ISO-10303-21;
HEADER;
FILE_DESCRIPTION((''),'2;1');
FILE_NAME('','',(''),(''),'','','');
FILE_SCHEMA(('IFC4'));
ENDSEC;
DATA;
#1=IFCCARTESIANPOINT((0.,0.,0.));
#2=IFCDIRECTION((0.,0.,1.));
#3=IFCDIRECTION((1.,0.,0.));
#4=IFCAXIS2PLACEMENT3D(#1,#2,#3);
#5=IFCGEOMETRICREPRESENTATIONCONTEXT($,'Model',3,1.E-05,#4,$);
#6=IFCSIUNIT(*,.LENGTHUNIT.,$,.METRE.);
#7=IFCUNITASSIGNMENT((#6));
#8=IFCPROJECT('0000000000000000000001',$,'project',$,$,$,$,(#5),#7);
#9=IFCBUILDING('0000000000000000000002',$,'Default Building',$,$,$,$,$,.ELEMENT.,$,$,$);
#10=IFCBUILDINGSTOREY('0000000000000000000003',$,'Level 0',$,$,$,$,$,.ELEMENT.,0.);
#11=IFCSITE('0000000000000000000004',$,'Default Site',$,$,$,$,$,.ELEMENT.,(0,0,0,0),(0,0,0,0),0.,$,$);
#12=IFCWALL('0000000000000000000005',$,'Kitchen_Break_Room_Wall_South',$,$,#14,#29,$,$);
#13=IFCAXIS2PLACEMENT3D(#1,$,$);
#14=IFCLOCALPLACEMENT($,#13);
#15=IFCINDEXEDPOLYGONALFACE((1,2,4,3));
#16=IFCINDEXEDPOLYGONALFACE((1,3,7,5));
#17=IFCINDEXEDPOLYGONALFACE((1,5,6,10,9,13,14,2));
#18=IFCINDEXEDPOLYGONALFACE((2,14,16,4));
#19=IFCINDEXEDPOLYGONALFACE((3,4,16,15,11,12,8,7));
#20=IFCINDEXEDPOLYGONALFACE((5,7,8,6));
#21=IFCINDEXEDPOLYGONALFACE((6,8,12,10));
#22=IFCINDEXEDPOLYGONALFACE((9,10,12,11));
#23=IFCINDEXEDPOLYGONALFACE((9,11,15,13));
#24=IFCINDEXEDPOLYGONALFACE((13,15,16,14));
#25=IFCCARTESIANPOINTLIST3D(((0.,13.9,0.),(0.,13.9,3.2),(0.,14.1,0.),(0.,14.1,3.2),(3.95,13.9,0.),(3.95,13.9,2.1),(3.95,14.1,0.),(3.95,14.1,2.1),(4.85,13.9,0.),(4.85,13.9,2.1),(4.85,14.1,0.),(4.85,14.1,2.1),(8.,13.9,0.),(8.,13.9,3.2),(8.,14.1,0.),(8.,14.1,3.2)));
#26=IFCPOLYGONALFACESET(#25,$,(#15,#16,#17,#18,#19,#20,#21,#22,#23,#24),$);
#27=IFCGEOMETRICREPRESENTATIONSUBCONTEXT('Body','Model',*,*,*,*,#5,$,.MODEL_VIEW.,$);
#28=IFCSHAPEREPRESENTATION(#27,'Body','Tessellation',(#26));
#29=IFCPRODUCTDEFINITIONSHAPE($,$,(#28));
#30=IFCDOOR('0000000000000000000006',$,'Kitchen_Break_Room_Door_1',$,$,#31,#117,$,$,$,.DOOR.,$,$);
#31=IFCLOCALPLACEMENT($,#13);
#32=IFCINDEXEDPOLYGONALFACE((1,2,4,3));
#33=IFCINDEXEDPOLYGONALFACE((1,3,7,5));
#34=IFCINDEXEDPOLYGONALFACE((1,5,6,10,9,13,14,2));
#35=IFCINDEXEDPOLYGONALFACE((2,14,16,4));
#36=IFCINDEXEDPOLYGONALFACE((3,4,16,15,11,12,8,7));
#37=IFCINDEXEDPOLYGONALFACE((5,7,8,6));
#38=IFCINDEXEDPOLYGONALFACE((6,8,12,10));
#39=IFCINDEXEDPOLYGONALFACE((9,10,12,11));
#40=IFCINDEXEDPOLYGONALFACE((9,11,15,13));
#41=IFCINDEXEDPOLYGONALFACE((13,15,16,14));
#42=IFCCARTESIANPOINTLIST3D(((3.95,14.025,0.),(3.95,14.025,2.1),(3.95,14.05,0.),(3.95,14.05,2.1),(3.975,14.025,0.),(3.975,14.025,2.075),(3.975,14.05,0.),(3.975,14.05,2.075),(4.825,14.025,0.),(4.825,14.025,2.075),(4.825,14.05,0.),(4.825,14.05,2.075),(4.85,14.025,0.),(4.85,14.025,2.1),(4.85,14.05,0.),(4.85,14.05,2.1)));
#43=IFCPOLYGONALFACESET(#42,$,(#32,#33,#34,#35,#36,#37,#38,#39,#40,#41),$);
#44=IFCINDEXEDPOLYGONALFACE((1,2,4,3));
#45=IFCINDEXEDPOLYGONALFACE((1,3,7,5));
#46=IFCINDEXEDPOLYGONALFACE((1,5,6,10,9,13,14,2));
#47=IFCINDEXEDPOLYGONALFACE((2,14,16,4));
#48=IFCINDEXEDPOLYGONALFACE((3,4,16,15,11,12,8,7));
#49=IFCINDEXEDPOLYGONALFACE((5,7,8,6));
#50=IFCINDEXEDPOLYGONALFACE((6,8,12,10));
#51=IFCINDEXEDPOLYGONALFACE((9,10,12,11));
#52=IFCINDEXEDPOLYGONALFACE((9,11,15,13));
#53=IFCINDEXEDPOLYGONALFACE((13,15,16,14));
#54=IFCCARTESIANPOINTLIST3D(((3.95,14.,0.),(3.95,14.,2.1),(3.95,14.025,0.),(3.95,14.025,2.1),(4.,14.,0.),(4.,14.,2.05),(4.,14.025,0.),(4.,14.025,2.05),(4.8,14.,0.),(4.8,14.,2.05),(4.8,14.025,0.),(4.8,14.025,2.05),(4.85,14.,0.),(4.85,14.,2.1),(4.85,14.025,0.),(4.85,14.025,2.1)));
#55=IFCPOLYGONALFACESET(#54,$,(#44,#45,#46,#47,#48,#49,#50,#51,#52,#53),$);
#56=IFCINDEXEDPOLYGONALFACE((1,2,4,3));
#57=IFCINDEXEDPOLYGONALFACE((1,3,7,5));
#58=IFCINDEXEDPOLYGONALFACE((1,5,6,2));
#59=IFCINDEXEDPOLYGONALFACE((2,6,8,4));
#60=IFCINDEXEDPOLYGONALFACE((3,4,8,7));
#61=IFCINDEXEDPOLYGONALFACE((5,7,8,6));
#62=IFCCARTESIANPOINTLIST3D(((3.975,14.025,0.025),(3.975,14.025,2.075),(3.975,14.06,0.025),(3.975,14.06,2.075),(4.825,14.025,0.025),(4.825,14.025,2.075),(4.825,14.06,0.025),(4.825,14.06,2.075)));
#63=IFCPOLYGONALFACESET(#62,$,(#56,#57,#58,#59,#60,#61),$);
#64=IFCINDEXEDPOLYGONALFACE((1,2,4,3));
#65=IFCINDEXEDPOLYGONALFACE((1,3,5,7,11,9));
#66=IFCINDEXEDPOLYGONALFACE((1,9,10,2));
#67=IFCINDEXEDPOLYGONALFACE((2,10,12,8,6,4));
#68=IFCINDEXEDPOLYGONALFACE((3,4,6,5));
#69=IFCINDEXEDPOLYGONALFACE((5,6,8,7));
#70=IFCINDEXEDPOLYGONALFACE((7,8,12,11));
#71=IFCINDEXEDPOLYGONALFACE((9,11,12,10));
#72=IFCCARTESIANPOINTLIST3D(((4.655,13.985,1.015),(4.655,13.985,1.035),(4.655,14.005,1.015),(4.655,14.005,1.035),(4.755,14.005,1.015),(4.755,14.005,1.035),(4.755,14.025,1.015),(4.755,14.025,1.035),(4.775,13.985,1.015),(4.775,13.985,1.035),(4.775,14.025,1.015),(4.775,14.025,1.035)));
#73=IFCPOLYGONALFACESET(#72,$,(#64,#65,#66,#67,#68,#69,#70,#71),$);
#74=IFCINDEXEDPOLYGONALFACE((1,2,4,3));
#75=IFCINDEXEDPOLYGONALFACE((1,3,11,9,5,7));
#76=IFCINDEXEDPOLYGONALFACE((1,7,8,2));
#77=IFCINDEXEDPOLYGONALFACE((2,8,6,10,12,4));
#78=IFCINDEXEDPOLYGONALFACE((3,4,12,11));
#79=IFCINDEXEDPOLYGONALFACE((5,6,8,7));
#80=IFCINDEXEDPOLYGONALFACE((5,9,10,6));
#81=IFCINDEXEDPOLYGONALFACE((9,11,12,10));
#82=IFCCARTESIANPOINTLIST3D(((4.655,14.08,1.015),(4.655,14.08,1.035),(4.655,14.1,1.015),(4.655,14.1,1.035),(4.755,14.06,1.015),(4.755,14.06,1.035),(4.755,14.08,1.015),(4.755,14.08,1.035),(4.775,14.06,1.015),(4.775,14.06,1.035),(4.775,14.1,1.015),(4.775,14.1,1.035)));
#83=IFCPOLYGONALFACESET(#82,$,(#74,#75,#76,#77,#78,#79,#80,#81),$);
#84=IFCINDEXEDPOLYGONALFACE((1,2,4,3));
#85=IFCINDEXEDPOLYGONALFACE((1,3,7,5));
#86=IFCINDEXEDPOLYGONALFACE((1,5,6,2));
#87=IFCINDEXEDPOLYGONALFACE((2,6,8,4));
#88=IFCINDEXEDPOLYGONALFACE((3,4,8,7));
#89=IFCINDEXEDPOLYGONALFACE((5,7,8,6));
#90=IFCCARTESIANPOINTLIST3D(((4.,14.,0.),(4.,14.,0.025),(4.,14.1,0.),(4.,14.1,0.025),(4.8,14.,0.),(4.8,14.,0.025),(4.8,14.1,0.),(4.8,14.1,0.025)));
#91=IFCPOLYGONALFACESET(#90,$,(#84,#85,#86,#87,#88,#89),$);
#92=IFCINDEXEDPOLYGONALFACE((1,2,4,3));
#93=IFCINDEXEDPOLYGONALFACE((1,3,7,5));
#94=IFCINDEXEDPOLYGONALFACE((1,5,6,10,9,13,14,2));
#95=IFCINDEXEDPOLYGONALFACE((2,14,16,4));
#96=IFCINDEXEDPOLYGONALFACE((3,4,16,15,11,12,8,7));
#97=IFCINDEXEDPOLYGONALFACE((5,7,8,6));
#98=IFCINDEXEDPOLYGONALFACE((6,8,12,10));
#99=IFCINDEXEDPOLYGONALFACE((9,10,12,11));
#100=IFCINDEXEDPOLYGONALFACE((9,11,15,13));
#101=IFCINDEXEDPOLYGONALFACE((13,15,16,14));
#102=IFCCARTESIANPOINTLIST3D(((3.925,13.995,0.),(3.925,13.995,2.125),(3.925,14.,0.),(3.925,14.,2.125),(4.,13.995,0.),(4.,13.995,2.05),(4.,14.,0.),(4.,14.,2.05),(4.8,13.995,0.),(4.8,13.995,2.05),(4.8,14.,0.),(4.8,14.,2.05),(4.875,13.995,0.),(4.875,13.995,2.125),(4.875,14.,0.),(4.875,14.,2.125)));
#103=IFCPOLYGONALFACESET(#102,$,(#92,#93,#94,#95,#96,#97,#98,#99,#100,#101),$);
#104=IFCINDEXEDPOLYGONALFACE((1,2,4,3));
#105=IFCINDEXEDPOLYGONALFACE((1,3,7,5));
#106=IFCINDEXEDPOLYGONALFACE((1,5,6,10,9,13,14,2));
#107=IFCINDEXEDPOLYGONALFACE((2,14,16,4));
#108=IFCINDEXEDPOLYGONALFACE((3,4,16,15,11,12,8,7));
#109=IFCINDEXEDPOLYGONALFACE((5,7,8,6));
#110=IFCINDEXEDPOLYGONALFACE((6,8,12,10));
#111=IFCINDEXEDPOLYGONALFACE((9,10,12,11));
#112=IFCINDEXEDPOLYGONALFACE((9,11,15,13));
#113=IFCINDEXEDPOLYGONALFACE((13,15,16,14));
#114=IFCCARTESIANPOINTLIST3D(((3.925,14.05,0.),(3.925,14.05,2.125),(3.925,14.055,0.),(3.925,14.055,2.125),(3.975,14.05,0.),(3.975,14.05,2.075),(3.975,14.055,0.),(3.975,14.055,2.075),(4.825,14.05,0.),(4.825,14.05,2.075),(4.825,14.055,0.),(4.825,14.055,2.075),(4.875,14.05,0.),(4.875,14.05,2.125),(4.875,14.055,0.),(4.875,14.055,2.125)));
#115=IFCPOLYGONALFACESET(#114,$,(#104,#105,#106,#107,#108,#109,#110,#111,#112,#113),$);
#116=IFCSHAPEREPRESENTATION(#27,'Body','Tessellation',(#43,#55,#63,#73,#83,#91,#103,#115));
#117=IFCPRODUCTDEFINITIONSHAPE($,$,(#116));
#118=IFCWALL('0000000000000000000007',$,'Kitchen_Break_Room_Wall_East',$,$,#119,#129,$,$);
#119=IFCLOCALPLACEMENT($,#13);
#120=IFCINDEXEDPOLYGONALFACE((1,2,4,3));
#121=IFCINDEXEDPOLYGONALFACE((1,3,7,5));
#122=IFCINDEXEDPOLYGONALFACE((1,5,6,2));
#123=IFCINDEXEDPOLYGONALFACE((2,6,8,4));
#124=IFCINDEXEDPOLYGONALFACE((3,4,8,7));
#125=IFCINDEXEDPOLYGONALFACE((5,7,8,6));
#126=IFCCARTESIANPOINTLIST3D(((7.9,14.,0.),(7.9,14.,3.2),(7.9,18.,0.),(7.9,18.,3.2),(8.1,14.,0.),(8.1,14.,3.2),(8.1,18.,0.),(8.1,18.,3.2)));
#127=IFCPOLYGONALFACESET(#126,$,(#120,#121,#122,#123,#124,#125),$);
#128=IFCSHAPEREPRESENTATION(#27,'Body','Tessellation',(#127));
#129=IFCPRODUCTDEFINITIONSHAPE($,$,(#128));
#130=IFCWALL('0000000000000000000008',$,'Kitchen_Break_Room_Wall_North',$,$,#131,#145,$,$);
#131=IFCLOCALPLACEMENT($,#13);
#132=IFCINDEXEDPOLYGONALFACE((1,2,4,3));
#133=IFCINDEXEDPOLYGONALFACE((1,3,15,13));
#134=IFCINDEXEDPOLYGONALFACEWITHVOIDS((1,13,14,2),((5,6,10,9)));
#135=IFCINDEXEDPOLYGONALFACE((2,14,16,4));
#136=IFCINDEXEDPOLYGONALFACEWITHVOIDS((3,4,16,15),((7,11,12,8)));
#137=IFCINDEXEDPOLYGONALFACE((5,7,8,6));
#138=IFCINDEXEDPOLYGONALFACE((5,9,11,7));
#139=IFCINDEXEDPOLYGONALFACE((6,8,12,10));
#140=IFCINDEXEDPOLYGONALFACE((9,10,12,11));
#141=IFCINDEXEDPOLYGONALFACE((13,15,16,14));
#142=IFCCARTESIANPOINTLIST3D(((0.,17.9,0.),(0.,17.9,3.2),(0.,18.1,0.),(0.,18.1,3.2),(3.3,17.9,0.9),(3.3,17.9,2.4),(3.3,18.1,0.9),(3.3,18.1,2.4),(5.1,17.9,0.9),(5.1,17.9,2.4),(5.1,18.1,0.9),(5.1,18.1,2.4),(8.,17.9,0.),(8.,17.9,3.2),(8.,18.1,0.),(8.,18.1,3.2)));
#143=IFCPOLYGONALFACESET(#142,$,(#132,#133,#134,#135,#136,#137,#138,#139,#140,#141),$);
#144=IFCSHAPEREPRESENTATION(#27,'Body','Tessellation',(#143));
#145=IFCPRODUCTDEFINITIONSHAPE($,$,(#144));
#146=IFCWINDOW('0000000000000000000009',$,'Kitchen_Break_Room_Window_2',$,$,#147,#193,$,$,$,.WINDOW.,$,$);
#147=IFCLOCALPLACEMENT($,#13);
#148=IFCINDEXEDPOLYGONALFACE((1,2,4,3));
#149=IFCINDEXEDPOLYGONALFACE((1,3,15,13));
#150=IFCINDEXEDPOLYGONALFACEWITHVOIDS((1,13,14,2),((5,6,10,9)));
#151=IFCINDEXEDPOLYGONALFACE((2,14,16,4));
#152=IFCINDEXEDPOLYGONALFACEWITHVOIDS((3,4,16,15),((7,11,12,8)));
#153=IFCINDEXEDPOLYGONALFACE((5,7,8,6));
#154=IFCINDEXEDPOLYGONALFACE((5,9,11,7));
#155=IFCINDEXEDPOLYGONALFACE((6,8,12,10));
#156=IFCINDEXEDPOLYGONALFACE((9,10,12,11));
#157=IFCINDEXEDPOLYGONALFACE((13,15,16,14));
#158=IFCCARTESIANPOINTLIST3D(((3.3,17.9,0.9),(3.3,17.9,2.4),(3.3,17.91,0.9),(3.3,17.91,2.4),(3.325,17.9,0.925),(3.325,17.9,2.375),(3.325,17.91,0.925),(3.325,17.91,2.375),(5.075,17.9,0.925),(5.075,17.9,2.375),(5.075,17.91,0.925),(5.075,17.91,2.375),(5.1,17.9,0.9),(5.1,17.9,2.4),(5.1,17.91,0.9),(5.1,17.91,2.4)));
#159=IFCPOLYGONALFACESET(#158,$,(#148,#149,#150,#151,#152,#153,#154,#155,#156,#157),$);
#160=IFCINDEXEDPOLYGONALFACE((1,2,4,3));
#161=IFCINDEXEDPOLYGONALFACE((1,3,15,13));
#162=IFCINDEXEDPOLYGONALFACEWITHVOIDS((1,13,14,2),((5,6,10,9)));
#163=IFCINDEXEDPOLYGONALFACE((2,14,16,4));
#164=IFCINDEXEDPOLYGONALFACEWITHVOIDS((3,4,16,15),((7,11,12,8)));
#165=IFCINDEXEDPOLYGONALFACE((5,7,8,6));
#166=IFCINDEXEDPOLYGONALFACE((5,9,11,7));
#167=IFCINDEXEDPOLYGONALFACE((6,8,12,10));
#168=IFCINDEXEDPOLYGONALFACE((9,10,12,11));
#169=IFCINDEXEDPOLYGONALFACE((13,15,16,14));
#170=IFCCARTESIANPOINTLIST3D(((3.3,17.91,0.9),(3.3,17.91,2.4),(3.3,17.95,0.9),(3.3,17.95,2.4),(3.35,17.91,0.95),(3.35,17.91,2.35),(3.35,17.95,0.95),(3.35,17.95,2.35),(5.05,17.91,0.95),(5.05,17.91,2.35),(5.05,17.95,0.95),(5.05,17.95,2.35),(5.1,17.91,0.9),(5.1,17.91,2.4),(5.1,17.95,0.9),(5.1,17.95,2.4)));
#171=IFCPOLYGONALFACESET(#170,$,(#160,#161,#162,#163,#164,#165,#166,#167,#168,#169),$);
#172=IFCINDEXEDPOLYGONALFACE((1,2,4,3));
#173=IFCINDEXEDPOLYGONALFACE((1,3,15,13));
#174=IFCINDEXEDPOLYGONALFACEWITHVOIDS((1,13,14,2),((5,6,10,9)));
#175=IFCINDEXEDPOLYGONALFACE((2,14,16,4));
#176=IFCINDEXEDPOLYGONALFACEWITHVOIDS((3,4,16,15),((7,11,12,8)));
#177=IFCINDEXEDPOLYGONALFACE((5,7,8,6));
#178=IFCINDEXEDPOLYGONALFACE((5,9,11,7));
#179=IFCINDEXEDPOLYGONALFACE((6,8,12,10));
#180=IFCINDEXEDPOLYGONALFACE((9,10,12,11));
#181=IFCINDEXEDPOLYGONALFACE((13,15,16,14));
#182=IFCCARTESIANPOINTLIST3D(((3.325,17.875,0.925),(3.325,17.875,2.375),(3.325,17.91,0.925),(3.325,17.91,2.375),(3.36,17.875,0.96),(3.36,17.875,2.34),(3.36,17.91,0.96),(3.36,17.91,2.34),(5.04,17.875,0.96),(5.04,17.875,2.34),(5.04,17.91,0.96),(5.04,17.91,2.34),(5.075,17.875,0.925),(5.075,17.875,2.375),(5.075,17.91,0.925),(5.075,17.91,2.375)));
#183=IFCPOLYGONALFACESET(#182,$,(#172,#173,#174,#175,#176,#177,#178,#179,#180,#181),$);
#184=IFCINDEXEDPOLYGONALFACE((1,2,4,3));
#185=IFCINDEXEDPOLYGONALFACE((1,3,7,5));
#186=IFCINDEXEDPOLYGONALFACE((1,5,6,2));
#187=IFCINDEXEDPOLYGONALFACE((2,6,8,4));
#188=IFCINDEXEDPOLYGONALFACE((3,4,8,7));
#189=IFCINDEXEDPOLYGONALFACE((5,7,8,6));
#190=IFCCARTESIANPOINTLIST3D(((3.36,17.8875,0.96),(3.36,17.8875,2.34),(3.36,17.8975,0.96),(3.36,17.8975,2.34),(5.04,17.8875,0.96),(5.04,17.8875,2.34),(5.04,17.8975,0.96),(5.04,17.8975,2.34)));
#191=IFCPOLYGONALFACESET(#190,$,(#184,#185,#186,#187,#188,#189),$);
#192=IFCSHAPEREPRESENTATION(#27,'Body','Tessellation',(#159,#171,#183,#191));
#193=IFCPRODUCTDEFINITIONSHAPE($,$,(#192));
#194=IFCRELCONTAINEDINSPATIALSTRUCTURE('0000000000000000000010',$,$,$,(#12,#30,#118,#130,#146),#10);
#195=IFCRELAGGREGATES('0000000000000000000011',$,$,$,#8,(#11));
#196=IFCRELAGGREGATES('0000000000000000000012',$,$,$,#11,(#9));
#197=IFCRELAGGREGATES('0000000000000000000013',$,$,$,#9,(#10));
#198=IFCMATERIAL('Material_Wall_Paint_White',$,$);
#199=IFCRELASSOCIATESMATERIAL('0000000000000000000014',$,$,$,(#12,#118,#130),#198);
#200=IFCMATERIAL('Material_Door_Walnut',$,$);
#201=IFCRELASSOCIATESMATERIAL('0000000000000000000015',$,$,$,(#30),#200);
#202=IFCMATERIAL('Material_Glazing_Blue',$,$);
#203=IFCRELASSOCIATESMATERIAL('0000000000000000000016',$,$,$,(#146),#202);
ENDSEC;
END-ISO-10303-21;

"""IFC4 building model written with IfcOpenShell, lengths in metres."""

from ifc_helpers import new_model, si_unit, frame, origin_with_axes, place, context, subcontext, project, spatial, line, indexed_curve, outline, extrude, material, element, fill, save


model = new_model("IFC4")

# Units and contexts
model_context = context("Model", 3, precision=1e-05, world=origin_with_axes())
body_context = subcontext(model_context, "Body", "Model", "MODEL_VIEW")
ifc_project = project(units=[si_unit("LENGTHUNIT", "METRE")], contexts=[model_context])

# Site, building, storey
site = spatial("IfcSite", under=ifc_project, Name="Default Site", CompositionType="ELEMENT", RefLatitude=(0, 0, 0, 0), RefLongitude=(0, 0, 0, 0), RefElevation=0.0)
building = spatial("IfcBuilding", under=site, Name="Default Building", CompositionType="ELEMENT")
storey = spatial("IfcBuildingStorey", under=building, Name="Level 0", CompositionType="ELEMENT", Elevation=0.0)

# Shared definitions
ifc_material_1 = material(Name="Material_Wall_Paint_White")

# Shared definitions
ifc_material_2 = material(Name="Material_Glazing_Blue")

# Shared definitions
ifc_material_3 = material(Name="Material_Door_Walnut")

# Wall, opening, door
wall_1_placement = place(None, frame((0.0, 14.0, 0.0), z_axis=(0.0, 0.0, 1.0), x_axis=(1.0, 0.0, 0.0)))
wall_1 = element("IfcWall", 1, at=wall_1_placement, inside=storey, material=ifc_material_1, Name="Kitchen_Break_Room_Wall_South", context=body_context, shape_type="SweptSolid", body=[
    extrude(outline(indexed_curve([(0.0, 0.0), (0.0, 0.2), (8.0, 0.2), (8.0, 0.0), (0.0, 0.0)], self_intersect=False)), frame((0.0, -0.1, 0.0), z_axis=(0.0, 0.0, 1.0), x_axis=(1.0, 0.0, 0.0)), (0.0, 0.0, 1.0), 3.2),
])
opening_1_placement = place(wall_1_placement, frame((3.95, -0.5, 0.0), z_axis=(0.0, 0.0, 1.0), x_axis=(1.0, 0.0, 0.0)))
opening_1 = element("IfcOpeningElement", 2, at=opening_1_placement, inside=storey, cuts=wall_1, PredefinedType="OPENING", context=body_context, shape_type="SweptSolid", body=[
    extrude(outline(indexed_curve([(0.0, 0.0), (0.0, 1.0), (0.9, 1.0), (0.9, 0.0), (0.0, 0.0)], self_intersect=False)), origin_with_axes(), (0.0, 0.0, 1.0), 2.1),
])
door_1_placement = place(None, frame((3.95, 14.0, 0.0), z_axis=(0.0, 0.0, 1.0), x_axis=(1.0, 0.0, 0.0)))
door_1 = element("IfcDoor", 3, at=door_1_placement, inside=storey, material=ifc_material_3, Name="Kitchen_Break_Room_Door_1", PredefinedType="DOOR", context=body_context, shape_type="SweptSolid", body=[
    extrude(outline(indexed_curve([(0.0, 0.0), (0.0, 2.1), (0.9, 2.1), (0.9, 0.0), (0.875, 0.0), (0.875, 2.075), (0.025, 2.075), (0.025, 0.0)], segments=[line(1, 2, 3, 4, 5, 6, 7, 8, 1)])), frame((0.0, 0.025, 0.0), z_axis=(0.0, -1.0, 0.0), x_axis=(1.0, 0.0, 0.0)), (0.0, 0.0, -1.0), 0.025),
    extrude(outline(indexed_curve([(0.0, 0.0), (0.0, 2.1), (0.9, 2.1), (0.9, 0.0), (0.85, 0.0), (0.85, 2.05), (0.05, 2.05), (0.05, 0.0)], segments=[line(1, 2, 3, 4, 5, 6, 7, 8, 1)])), frame((0.0, 0.0, 0.0), z_axis=(0.0, -1.0, 0.0), x_axis=(1.0, 0.0, 0.0)), (0.0, 0.0, -1.0), 0.025),
    extrude(outline(indexed_curve([(0.0, 0.0), (0.85, 0.0), (0.85, 0.035), (0.0, 0.035)], segments=[line(1, 2, 3, 4, 1)])), frame((0.025, 0.025, 0.025), z_axis=(0.0, 0.0, 1.0), x_axis=(1.0, 0.0, 0.0)), (0.0, 0.0, 1.0), 2.05),
    extrude(outline(indexed_curve([(0.0, 0.0), (0.0, -0.04), (-0.12, -0.04), (-0.12, -0.02), (-0.02, -0.02), (-0.02, 0.0)], segments=[line(1, 2, 3, 4, 5, 6, 1)])), frame((0.825, 0.025, 1.015), z_axis=(0.0, 0.0, 1.0), x_axis=(1.0, 0.0, 0.0)), (0.0, 0.0, 1.0), 0.02),
    extrude(outline(indexed_curve([(0.0, 0.0), (0.0, 0.04), (-0.12, 0.04), (-0.12, 0.02), (-0.02, 0.02), (-0.02, 0.0)], segments=[line(1, 2, 3, 4, 5, 6, 1)])), frame((0.825, 0.06, 1.015), z_axis=(0.0, 0.0, 1.0), x_axis=(1.0, 0.0, 0.0)), (0.0, 0.0, 1.0), 0.02),
    extrude(outline(indexed_curve([(0.0, 0.0), (0.8, 0.0), (0.8, 0.1), (0.0, 0.1)], segments=[line(1, 2, 3, 4, 1)])), frame((0.05, 0.0, 0.0), z_axis=(0.0, 0.0, 1.0), x_axis=(1.0, 0.0, 0.0)), (0.0, 0.0, 1.0), 0.025),
    extrude(outline(indexed_curve([(0.0, 0.0), (0.0, 2.125), (0.95, 2.125), (0.95, 0.0), (0.875, 0.0), (0.875, 2.05), (0.075, 2.05), (0.075, 0.0)], segments=[line(1, 2, 3, 4, 5, 6, 7, 8, 1)])), frame((-0.025, -0.005, 0.0), z_axis=(0.0, -1.0, 0.0), x_axis=(1.0, 0.0, 0.0)), (0.0, 0.0, -1.0), 0.005),
    extrude(outline(indexed_curve([(0.0, 0.0), (0.0, 2.125), (0.95, 2.125), (0.95, 0.0), (0.9, 0.0), (0.9, 2.075), (0.05, 2.075), (0.05, 0.0)], segments=[line(1, 2, 3, 4, 5, 6, 7, 8, 1)])), frame((-0.025, 0.05, 0.0), z_axis=(0.0, -1.0, 0.0), x_axis=(1.0, 0.0, 0.0)), (0.0, 0.0, -1.0), 0.005),
])
fill(opening_1, door_1)

# Wall
wall_2_placement = place(None, frame((8.0, 14.0, 0.0), z_axis=(0.0, 0.0, 1.0), x_axis=(0.0, 1.0, 0.0)))
element("IfcWall", 4, at=wall_2_placement, inside=storey, material=ifc_material_1, Name="Kitchen_Break_Room_Wall_East", context=body_context, shape_type="SweptSolid", body=[
    extrude(outline(indexed_curve([(0.0, 0.0), (0.0, 0.2), (4.0, 0.2), (4.0, 0.0), (0.0, 0.0)], self_intersect=False)), frame((0.0, -0.1, 0.0), z_axis=(0.0, 0.0, 1.0), x_axis=(1.0, 0.0, 0.0)), (0.0, 0.0, 1.0), 3.2),
])

# Wall, opening, window
wall_3_placement = place(None, frame((8.0, 18.0, 0.0), z_axis=(0.0, 0.0, 1.0), x_axis=(-1.0, 0.0, 0.0)))
wall_3 = element("IfcWall", 5, at=wall_3_placement, inside=storey, material=ifc_material_1, Name="Kitchen_Break_Room_Wall_North", context=body_context, shape_type="SweptSolid", body=[
    extrude(outline(indexed_curve([(0.0, 0.0), (0.0, 0.2), (8.0, 0.2), (8.0, 0.0), (0.0, 0.0)], self_intersect=False)), frame((0.0, -0.1, 0.0), z_axis=(0.0, 0.0, 1.0), x_axis=(1.0, 0.0, 0.0)), (0.0, 0.0, 1.0), 3.2),
])
opening_2_placement = place(wall_3_placement, frame((2.9, -0.5, 0.9), z_axis=(0.0, 0.0, 1.0), x_axis=(1.0, 0.0, 0.0)))
opening_2 = element("IfcOpeningElement", 6, at=opening_2_placement, inside=storey, cuts=wall_3, PredefinedType="OPENING", context=body_context, shape_type="SweptSolid", body=[
    extrude(outline(indexed_curve([(0.0, 0.0), (0.0, 1.0), (1.8, 1.0), (1.8, 0.0), (0.0, 0.0)], self_intersect=False)), origin_with_axes(), (0.0, 0.0, 1.0), 1.5),
])
window_1_placement = place(None, frame((5.1, 18.0, 0.9), z_axis=(0.0, 0.0, 1.0), x_axis=(-1.0, 0.0, 0.0)))
window_1 = element("IfcWindow", 7, at=window_1_placement, inside=storey, material=ifc_material_2, Name="Kitchen_Break_Room_Window_2", PredefinedType="WINDOW", context=body_context, shape_type="SweptSolid", body=[
    extrude(outline(indexed_curve([(0.0, 0.0), (1.8, 0.0), (1.8, 1.5), (0.0, 1.5)], segments=[line(1, 2, 3, 4, 1)]), holes=[indexed_curve([(0.025, 0.025), (1.775, 0.025), (1.775, 1.475), (0.025, 1.475)], segments=[line(1, 2, 3, 4, 1)])]), frame((0.0, 0.09, 0.0), z_axis=(0.0, -1.0, 0.0), x_axis=(1.0, 0.0, 0.0)), (0.0, 0.0, -1.0), 0.01),
    extrude(outline(indexed_curve([(0.0, 0.0), (1.8, 0.0), (1.8, 1.5), (0.0, 1.5)], segments=[line(1, 2, 3, 4, 1)]), holes=[indexed_curve([(0.05, 0.05), (1.75, 0.05), (1.75, 1.45), (0.05, 1.45)], segments=[line(1, 2, 3, 4, 1)])]), frame((0.0, 0.05, 0.0), z_axis=(0.0, -1.0, 0.0), x_axis=(1.0, 0.0, 0.0)), (0.0, 0.0, -1.0), 0.04),
    extrude(outline(indexed_curve([(0.0, 0.0), (1.75, 0.0), (1.75, 1.45), (0.0, 1.45)], segments=[line(1, 2, 3, 4, 1)]), holes=[indexed_curve([(0.035, 0.035), (1.715, 0.035), (1.715, 1.415), (0.035, 1.415)], segments=[line(1, 2, 3, 4, 1)])]), frame((0.025, 0.09, 0.025), z_axis=(0.0, -1.0, 0.0), x_axis=(1.0, 0.0, 0.0)), (0.0, 0.0, -1.0), 0.035),
    extrude(outline(indexed_curve([(0.035, 0.035), (1.715, 0.035), (1.715, 1.415), (0.035, 1.415)], segments=[line(1, 2, 3, 4, 1)])), frame((0.025, 0.1025, 0.025), z_axis=(0.0, -1.0, 0.0), x_axis=(1.0, 0.0, 0.0)), (0.0, 0.0, -1.0), 0.01),
])
fill(opening_2, window_1)

save(model, "model.ifc")
